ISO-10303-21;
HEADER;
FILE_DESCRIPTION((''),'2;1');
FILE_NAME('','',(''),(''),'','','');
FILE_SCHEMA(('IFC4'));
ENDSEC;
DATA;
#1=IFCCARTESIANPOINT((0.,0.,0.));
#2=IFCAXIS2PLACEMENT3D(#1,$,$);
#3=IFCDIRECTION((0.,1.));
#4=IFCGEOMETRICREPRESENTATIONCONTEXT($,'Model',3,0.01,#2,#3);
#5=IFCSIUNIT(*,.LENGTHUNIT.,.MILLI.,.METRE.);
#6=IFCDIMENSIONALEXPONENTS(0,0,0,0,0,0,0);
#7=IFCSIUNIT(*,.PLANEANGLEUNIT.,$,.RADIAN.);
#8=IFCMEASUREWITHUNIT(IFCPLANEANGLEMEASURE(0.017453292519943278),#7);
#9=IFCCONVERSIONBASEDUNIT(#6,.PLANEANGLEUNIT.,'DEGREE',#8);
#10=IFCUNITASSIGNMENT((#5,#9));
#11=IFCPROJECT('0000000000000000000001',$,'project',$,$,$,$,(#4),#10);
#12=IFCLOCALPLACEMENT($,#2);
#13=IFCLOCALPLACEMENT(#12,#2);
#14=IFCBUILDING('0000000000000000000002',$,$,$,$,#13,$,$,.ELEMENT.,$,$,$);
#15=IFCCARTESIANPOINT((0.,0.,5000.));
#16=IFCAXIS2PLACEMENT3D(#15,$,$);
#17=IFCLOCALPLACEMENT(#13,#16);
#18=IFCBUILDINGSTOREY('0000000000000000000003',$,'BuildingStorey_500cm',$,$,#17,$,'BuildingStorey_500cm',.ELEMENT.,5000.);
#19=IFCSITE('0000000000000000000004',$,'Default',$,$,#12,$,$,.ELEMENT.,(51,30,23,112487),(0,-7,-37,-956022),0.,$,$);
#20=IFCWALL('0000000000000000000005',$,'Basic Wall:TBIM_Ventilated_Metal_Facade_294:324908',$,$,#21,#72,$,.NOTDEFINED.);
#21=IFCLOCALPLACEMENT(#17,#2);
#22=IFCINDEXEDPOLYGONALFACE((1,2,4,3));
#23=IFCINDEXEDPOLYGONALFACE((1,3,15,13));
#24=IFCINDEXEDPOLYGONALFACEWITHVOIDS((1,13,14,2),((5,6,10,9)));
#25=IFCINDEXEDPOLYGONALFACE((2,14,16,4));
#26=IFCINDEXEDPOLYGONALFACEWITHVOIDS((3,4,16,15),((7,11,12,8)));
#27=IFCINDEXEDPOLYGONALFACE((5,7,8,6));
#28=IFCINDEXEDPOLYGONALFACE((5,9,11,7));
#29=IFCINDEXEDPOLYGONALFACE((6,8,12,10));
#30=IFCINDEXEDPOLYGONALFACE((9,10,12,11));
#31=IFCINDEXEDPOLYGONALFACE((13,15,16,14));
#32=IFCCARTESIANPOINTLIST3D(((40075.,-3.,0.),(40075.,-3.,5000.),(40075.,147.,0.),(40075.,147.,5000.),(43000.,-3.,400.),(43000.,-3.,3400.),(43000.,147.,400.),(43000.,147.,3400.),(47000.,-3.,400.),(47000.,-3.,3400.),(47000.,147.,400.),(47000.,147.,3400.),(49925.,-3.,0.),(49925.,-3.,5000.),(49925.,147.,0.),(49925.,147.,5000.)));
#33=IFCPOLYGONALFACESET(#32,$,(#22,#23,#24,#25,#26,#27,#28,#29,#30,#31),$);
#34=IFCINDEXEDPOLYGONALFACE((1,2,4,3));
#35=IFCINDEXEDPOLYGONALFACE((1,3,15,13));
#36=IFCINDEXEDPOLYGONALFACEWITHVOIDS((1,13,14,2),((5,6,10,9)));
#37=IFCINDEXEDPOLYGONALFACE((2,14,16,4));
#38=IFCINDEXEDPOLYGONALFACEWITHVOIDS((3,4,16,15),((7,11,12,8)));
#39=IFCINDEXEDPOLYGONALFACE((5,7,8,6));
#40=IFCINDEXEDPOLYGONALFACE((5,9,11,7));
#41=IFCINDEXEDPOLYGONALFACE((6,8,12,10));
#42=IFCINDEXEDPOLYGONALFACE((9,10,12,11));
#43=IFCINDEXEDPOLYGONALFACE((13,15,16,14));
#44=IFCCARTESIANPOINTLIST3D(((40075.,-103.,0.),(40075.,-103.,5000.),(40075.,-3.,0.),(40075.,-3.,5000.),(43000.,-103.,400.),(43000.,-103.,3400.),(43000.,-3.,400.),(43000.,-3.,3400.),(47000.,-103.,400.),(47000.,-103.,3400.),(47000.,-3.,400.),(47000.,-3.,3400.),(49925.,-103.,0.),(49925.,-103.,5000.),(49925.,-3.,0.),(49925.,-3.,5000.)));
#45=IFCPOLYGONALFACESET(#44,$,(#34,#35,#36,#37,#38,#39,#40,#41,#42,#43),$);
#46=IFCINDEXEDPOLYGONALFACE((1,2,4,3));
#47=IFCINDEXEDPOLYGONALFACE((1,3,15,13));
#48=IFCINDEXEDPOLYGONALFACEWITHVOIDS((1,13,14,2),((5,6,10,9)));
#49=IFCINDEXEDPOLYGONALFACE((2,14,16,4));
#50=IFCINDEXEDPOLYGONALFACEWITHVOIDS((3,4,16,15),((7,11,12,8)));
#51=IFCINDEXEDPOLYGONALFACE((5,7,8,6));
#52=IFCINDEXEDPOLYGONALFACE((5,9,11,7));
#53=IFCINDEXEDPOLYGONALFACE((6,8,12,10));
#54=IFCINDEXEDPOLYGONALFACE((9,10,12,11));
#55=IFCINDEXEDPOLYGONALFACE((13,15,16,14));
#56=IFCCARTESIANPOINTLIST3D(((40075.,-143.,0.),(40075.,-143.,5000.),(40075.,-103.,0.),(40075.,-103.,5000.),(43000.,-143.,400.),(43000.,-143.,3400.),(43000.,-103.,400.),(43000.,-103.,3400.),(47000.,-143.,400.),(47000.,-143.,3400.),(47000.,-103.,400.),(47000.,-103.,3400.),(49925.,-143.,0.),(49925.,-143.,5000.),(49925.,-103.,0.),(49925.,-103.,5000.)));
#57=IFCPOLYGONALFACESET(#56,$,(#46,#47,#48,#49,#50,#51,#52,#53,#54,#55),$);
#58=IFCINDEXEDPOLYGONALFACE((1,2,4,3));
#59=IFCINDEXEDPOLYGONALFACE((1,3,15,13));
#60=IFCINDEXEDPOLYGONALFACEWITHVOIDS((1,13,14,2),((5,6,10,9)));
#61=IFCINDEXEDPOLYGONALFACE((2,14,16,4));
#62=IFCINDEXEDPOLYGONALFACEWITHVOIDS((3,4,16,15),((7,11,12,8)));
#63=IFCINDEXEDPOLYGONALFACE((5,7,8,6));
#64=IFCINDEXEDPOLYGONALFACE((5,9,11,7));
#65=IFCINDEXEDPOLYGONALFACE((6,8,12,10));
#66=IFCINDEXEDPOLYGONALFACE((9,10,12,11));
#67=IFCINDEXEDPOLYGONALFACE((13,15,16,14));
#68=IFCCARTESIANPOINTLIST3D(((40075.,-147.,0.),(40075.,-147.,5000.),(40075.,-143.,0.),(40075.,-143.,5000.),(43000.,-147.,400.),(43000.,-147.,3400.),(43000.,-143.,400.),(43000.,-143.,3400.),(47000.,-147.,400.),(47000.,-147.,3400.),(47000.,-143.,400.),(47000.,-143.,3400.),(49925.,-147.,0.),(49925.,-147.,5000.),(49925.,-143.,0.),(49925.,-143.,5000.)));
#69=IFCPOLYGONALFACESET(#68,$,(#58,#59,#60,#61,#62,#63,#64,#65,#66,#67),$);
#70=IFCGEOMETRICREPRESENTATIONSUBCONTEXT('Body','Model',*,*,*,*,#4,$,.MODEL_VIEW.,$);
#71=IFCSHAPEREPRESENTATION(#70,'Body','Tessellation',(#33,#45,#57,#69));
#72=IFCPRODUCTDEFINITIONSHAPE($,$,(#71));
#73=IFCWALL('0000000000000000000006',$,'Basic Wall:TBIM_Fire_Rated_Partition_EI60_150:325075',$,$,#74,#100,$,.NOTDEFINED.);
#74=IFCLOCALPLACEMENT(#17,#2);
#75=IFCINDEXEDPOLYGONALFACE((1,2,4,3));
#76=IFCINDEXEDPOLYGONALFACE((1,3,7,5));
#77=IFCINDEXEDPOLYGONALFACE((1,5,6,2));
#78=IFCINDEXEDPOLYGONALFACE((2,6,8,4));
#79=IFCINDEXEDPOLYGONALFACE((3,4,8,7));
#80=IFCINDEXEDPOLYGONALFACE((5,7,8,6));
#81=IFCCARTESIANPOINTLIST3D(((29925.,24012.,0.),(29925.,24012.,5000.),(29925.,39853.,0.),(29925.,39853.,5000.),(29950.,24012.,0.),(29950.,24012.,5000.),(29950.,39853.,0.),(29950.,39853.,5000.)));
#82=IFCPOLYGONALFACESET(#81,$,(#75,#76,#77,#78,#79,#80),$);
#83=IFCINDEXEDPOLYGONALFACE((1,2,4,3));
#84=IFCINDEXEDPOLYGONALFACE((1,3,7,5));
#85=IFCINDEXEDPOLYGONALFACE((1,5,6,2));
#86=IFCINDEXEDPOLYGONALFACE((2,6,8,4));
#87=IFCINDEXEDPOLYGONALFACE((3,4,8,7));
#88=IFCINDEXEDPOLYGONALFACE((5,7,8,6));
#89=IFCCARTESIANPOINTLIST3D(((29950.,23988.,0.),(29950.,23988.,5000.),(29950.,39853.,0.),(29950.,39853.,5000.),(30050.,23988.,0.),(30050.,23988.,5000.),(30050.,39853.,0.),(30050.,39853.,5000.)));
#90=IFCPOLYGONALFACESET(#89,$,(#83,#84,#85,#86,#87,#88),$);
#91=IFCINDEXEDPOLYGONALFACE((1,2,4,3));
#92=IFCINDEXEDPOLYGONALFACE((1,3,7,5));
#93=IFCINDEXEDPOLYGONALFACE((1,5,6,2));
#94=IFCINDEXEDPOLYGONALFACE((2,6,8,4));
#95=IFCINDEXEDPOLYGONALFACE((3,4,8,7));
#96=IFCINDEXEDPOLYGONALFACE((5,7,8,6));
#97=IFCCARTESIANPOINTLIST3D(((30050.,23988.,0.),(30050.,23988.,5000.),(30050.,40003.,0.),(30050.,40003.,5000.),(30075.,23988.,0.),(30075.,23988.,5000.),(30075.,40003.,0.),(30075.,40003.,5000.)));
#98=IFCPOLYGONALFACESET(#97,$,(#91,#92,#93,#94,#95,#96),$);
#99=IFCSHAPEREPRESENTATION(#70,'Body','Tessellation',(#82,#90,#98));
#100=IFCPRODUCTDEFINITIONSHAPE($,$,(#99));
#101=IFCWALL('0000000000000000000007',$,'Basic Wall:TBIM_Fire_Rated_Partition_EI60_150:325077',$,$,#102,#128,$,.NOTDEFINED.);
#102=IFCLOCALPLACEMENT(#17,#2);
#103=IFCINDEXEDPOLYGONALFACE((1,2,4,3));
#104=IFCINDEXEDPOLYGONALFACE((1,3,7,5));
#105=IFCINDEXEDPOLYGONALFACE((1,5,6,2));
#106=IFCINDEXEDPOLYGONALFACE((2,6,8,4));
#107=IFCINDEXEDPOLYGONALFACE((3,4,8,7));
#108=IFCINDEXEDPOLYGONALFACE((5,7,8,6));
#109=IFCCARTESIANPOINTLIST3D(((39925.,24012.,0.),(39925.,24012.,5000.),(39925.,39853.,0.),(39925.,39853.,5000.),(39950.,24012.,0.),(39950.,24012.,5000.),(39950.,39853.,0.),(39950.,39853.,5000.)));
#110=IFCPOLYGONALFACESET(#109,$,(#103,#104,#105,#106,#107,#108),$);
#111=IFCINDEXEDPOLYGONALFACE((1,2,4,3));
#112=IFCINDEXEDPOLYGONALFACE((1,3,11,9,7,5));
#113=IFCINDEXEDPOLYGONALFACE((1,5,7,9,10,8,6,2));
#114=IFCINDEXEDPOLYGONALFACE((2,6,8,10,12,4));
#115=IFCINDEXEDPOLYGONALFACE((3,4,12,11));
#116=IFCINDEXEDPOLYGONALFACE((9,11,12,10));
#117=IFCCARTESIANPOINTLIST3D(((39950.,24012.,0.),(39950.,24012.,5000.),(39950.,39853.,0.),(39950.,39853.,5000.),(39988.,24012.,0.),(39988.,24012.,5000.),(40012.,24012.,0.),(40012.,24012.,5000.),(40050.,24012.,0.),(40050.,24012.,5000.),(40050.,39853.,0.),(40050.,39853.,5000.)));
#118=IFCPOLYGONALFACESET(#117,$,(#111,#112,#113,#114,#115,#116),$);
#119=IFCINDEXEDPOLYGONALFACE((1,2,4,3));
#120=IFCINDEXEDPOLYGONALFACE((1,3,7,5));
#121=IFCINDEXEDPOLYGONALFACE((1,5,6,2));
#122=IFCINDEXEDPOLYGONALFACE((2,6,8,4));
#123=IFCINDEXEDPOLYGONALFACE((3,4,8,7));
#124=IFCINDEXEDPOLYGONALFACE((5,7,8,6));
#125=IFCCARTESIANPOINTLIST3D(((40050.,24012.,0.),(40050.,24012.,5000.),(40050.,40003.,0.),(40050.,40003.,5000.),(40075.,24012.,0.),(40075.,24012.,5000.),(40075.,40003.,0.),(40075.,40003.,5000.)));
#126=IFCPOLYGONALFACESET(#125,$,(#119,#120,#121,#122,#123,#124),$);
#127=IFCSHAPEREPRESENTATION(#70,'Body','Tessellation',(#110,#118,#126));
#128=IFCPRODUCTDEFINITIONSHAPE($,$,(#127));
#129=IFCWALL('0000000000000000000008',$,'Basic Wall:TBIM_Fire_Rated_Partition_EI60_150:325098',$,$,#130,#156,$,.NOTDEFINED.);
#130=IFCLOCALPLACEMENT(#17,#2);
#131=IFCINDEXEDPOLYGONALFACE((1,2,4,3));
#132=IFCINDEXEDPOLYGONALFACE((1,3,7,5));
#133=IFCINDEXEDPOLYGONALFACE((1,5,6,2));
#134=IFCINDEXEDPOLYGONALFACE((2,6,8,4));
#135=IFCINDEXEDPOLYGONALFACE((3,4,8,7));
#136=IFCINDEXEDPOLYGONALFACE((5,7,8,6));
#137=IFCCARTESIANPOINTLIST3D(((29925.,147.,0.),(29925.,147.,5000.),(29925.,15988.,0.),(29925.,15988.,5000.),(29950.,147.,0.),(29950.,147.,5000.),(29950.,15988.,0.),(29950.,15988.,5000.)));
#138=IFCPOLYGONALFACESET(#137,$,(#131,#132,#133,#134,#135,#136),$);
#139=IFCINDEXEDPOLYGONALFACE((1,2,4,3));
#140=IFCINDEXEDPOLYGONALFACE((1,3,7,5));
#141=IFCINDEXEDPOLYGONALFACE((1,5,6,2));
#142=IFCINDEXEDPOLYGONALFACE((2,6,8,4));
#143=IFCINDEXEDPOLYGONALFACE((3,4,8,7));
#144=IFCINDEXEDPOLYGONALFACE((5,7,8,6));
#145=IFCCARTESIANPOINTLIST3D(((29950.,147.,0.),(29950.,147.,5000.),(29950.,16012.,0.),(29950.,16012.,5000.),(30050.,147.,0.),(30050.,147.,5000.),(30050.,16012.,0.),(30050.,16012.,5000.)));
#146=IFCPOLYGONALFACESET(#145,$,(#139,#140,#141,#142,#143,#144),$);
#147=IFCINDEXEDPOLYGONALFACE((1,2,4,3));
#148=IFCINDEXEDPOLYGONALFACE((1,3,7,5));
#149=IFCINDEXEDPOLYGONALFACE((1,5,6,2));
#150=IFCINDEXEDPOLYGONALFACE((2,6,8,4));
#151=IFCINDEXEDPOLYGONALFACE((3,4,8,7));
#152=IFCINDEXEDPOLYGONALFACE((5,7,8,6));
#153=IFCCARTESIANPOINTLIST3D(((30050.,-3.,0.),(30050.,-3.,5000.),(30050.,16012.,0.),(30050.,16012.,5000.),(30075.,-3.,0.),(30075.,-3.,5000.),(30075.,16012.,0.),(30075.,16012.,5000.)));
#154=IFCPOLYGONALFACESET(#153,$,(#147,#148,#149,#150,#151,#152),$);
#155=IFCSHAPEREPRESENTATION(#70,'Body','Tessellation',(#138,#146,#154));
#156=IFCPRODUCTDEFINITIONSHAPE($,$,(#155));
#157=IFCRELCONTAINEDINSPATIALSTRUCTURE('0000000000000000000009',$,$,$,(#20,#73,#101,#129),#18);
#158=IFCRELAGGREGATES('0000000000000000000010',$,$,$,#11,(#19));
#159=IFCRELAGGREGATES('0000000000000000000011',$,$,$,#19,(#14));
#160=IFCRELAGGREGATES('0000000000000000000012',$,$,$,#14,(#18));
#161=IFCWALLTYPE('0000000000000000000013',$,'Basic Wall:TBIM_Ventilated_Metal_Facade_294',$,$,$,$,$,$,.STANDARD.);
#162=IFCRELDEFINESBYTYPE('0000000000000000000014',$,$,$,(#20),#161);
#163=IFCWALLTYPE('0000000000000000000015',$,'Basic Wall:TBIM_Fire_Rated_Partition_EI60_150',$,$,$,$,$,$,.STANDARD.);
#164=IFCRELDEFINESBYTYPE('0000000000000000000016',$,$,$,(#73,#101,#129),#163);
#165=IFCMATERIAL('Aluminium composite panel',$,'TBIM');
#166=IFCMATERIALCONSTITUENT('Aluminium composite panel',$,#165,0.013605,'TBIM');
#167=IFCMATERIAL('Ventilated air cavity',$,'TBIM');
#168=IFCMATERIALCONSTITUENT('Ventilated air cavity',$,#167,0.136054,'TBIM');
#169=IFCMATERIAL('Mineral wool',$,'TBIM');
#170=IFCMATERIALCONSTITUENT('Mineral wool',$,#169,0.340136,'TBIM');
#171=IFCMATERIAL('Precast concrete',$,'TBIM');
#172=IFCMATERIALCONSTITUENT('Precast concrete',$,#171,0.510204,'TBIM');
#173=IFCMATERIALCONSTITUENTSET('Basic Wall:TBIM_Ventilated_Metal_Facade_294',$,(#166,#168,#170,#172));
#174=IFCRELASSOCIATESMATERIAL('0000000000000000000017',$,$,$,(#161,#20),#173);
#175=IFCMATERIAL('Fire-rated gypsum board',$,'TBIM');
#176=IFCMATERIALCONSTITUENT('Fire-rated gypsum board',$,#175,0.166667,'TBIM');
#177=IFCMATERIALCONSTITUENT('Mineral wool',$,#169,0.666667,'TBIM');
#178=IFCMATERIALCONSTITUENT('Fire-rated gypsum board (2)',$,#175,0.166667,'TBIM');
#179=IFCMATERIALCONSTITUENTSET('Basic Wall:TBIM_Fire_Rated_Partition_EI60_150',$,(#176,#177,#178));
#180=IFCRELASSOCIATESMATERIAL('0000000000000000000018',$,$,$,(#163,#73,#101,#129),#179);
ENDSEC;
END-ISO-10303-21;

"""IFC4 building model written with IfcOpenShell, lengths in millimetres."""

from ifc_helpers import new_model, entity, si_unit, converted_unit, direction, frame, origin, place, context, subcontext, project, spatial, indexed_curve, outline, extrude, material, constituent, constituent_set, type_object, element, save


model = new_model("IFC4")

# Units and contexts
model_context = context("Model", 3, precision=0.01, world=origin(), true_north=direction((0.0, 1.0)))
body_context = subcontext(model_context, "Body", "Model", "MODEL_VIEW")
ifc_project = project(units=[si_unit("LENGTHUNIT", "METRE", prefix="MILLI"), converted_unit("PLANEANGLEUNIT", "DEGREE", entity("IfcPlaneAngleMeasure", 0.017453292519943278), si_unit("PLANEANGLEUNIT", "RADIAN"), dimensions=[0, 0, 0, 0, 0, 0, 0])], contexts=[model_context])

# Site, building, storey
site_placement = place(None, origin())
site = spatial("IfcSite", under=ifc_project, at=site_placement, Name="Default", CompositionType="ELEMENT", RefLatitude=(51, 30, 23, 112487), RefLongitude=(0, -7, -37, -956022), RefElevation=0.0)
building_placement = place(site_placement, origin())
building = spatial("IfcBuilding", under=site, at=building_placement, CompositionType="ELEMENT")
storey_placement = place(building_placement, frame((0.0, 0.0, 5000.0)))
storey = spatial("IfcBuildingStorey", under=building, at=storey_placement, Name="BuildingStorey_500cm", LongName="BuildingStorey_500cm", CompositionType="ELEMENT", Elevation=5000.0)

# Wall, opening
ifc_material_1 = material(Name="Aluminium composite panel", Category="TBIM")
ifc_constituent_1 = constituent(ifc_material_1, Name="Aluminium composite panel", Category="TBIM", fraction=0.013605)
ifc_material_2 = material(Name="Ventilated air cavity", Category="TBIM")
ifc_constituent_2 = constituent(ifc_material_2, Name="Ventilated air cavity", Category="TBIM", fraction=0.136054)
ifc_material_3 = material(Name="Mineral wool", Category="TBIM")
ifc_constituent_3 = constituent(ifc_material_3, Name="Mineral wool", Category="TBIM", fraction=0.340136)
ifc_material_4 = material(Name="Precast concrete", Category="TBIM")
ifc_constituent_4 = constituent(ifc_material_4, Name="Precast concrete", Category="TBIM", fraction=0.510204)
ifc_constituent_set_1 = constituent_set(constituents=[ifc_constituent_1, ifc_constituent_2, ifc_constituent_3, ifc_constituent_4], Name="Basic Wall:TBIM_Ventilated_Metal_Facade_294")
wall_type_1 = type_object("IfcWallType", Name="Basic Wall:TBIM_Ventilated_Metal_Facade_294", PredefinedType="STANDARD", material=ifc_constituent_set_1)
wall_1_placement = place(storey_placement, frame((40075.0, 0.0, 0.0)))
wall_1 = element("IfcWall", 1, at=wall_1_placement, inside=storey, type_object=wall_type_1, material=ifc_constituent_set_1, Name="Basic Wall:TBIM_Ventilated_Metal_Facade_294:324908", PredefinedType="NOTDEFINED", context=body_context, shape_type="SweptSolid", body=[
    extrude(outline(indexed_curve([(-2500.0, -4925.0), (2500.0, -4925.0), (2500.0, 4925.0), (-2500.0, 4925.0), (-2500.0, -4925.0)], self_intersect=False), holes=[indexed_curve([(-2100.0, -2000.0), (-2100.0, 2000.0), (900.0, 2000.0), (900.0, -2000.0), (-2100.0, -2000.0)], self_intersect=False)]), frame((4925.0, -3.0, 2500.0), z_axis=(0.0, 1.0, 0.0), x_axis=(0.0, 0.0, 1.0)), (0.0, 0.0, 1.0), 150.0),
    extrude(outline(indexed_curve([(-2500.0, -4925.0), (2500.0, -4925.0), (2500.0, 4925.0), (-2500.0, 4925.0), (-2500.0, -4925.0)], self_intersect=False), holes=[indexed_curve([(-2100.0, -2000.0), (-2100.0, 2000.0), (900.0, 2000.0), (900.0, -2000.0), (-2100.0, -2000.0)], self_intersect=False)]), frame((4925.0, -103.0, 2500.0), z_axis=(0.0, 1.0, 0.0), x_axis=(0.0, 0.0, 1.0)), (0.0, 0.0, 1.0), 100.0),
    extrude(outline(indexed_curve([(-2500.0, -4925.0), (2500.0, -4925.0), (2500.0, 4925.0), (-2500.0, 4925.0), (-2500.0, -4925.0)], self_intersect=False), holes=[indexed_curve([(-2100.0, -2000.0), (-2100.0, 2000.0), (900.0, 2000.0), (900.0, -2000.0), (-2100.0, -2000.0)], self_intersect=False)]), frame((4925.0, -143.0, 2500.0), z_axis=(0.0, 1.0, 0.0), x_axis=(0.0, 0.0, 1.0)), (0.0, 0.0, 1.0), 40.0),
    extrude(outline(indexed_curve([(-2500.0, -4925.0), (2500.0, -4925.0), (2500.0, 4925.0), (-2500.0, 4925.0), (-2500.0, -4925.0)], self_intersect=False), holes=[indexed_curve([(900.0, -2000.0), (-2100.0, -2000.0), (-2100.0, 2000.0), (900.0, 2000.0), (900.0, -2000.0)], self_intersect=False)]), frame((4925.0, -147.0, 2500.0), z_axis=(0.0, 1.0, 0.0), x_axis=(0.0, 0.0, 1.0)), (0.0, 0.0, 1.0), 4.0),
])
opening_1_placement = place(wall_1_placement, frame((2925.0, -147.0, 400.0)))
element("IfcOpeningElement", 2, at=opening_1_placement, cuts=wall_1, PredefinedType="OPENING", context=body_context, shape_type="SweptSolid", body=[
    extrude(outline(indexed_curve([(3000.0, 0.0), (3000.0, 4000.0), (0.0, 4000.0), (0.0, 0.0), (3000.0, 0.0)], self_intersect=False)), frame((0.0, 0.0, 0.0), z_axis=(0.0, 1.0, 0.0), x_axis=(0.0, 0.0, 1.0)), (0.0, 0.0, 1.0), 294.0),
])

# Walls
ifc_material_5 = material(Name="Fire-rated gypsum board", Category="TBIM")
ifc_constituent_5 = constituent(ifc_material_5, Name="Fire-rated gypsum board", Category="TBIM", fraction=0.166667)
ifc_constituent_6 = constituent(ifc_material_3, Name="Mineral wool", Category="TBIM", fraction=0.666667)
ifc_constituent_7 = constituent(ifc_material_5, Name="Fire-rated gypsum board (2)", Category="TBIM", fraction=0.166667)
ifc_constituent_set_2 = constituent_set(constituents=[ifc_constituent_5, ifc_constituent_6, ifc_constituent_7], Name="Basic Wall:TBIM_Fire_Rated_Partition_EI60_150")
wall_type_2 = type_object("IfcWallType", Name="Basic Wall:TBIM_Fire_Rated_Partition_EI60_150", PredefinedType="STANDARD", material=ifc_constituent_set_2)
wall_2_placement = place(storey_placement, frame((30000.0, 24012.0, 0.0), z_axis=(0.0, 0.0, 1.0), x_axis=(0.0, 1.0, 0.0)))
element("IfcWall", 3, at=wall_2_placement, inside=storey, type_object=wall_type_2, material=ifc_constituent_set_2, Name="Basic Wall:TBIM_Fire_Rated_Partition_EI60_150:325075", PredefinedType="NOTDEFINED", context=body_context, shape_type="SweptSolid", body=[
    extrude(outline(indexed_curve([(-12.5, -7920.5), (12.5, -7920.5), (12.5, 7920.5), (-12.5, 7920.5), (-12.5, -7920.5)], self_intersect=False)), frame((7920.5, 62.5, 0.0), z_axis=(0.0, 0.0, 1.0), x_axis=(0.0, -1.0, 0.0)), (0.0, 0.0, 1.0), 5000.0),
    extrude(outline(indexed_curve([(-7932.5, -50.0), (7932.5, -50.0), (7932.5, 50.0), (-7932.5, 50.0), (-7932.5, -50.0)], self_intersect=False)), frame((7908.5, 0.0, 0.0)), (0.0, 0.0, 1.0), 5000.0),
    extrude(outline(indexed_curve([(-12.5, -8007.5), (12.5, -8007.5), (12.5, 8007.5), (-12.5, 8007.5), (-12.5, -8007.5)], self_intersect=False)), frame((7983.5, -62.5, 0.0), z_axis=(0.0, 0.0, 1.0), x_axis=(0.0, 1.0, 0.0)), (0.0, 0.0, 1.0), 5000.0),
])
wall_3_placement = place(storey_placement, frame((40000.0, 24012.0, 0.0), z_axis=(0.0, 0.0, 1.0), x_axis=(0.0, 1.0, 0.0)))
element("IfcWall", 4, at=wall_3_placement, inside=storey, type_object=wall_type_2, material=ifc_constituent_set_2, Name="Basic Wall:TBIM_Fire_Rated_Partition_EI60_150:325077", PredefinedType="NOTDEFINED", context=body_context, shape_type="SweptSolid", body=[
    extrude(outline(indexed_curve([(-12.5, -7920.5), (12.5, -7920.5), (12.5, 7920.5), (-12.5, 7920.5), (-12.5, -7920.5)], self_intersect=False)), frame((7920.5, 62.5, 0.0), z_axis=(0.0, 0.0, 1.0), x_axis=(0.0, -1.0, 0.0)), (0.0, 0.0, 1.0), 5000.0),
    extrude(outline(indexed_curve([(12.0, -5280.3), (50.0, -5280.3), (50.0, 10560.7), (-50.0, 10560.7), (-50.0, -5280.3), (-12.0, -5280.3), (12.0, -5280.3)], self_intersect=False)), frame((5280.3, 0.0, 0.0), z_axis=(0.0, 0.0, 1.0), x_axis=(0.0, -1.0, 0.0)), (0.0, 0.0, 1.0), 5000.0),
    extrude(outline(indexed_curve([(-12.5, -7995.5), (12.5, -7995.5), (12.5, 7995.5), (-12.5, 7995.5), (-12.5, -7995.5)], self_intersect=False)), frame((7995.5, -62.5, 0.0), z_axis=(0.0, 0.0, 1.0), x_axis=(0.0, 1.0, 0.0)), (0.0, 0.0, 1.0), 5000.0),
])
wall_4_placement = place(storey_placement, frame((30000.0, 147.0, 0.0), z_axis=(0.0, 0.0, 1.0), x_axis=(0.0, 1.0, 0.0)))
element("IfcWall", 5, at=wall_4_placement, inside=storey, type_object=wall_type_2, material=ifc_constituent_set_2, Name="Basic Wall:TBIM_Fire_Rated_Partition_EI60_150:325098", PredefinedType="NOTDEFINED", context=body_context, shape_type="SweptSolid", body=[
    extrude(outline(indexed_curve([(-12.5, -7920.5), (12.5, -7920.5), (12.5, 7920.5), (-12.5, 7920.5), (-12.5, -7920.5)], self_intersect=False)), frame((7920.5, 62.5, 0.0), z_axis=(0.0, 0.0, 1.0), x_axis=(0.0, -1.0, 0.0)), (0.0, 0.0, 1.0), 5000.0),
    extrude(outline(indexed_curve([(-7932.5, -50.0), (7932.5, -50.0), (7932.5, 50.0), (-7932.5, 50.0), (-7932.5, -50.0)], self_intersect=False)), frame((7932.5, 0.0, 0.0)), (0.0, 0.0, 1.0), 5000.0),
    extrude(outline(indexed_curve([(-12.5, -8007.5), (12.5, -8007.5), (12.5, 8007.5), (-12.5, 8007.5), (-12.5, -8007.5)], self_intersect=False)), frame((7857.5, -62.5, 0.0), z_axis=(0.0, 0.0, 1.0), x_axis=(0.0, 1.0, 0.0)), (0.0, 0.0, 1.0), 5000.0),
])

save(model, "model.ifc")
